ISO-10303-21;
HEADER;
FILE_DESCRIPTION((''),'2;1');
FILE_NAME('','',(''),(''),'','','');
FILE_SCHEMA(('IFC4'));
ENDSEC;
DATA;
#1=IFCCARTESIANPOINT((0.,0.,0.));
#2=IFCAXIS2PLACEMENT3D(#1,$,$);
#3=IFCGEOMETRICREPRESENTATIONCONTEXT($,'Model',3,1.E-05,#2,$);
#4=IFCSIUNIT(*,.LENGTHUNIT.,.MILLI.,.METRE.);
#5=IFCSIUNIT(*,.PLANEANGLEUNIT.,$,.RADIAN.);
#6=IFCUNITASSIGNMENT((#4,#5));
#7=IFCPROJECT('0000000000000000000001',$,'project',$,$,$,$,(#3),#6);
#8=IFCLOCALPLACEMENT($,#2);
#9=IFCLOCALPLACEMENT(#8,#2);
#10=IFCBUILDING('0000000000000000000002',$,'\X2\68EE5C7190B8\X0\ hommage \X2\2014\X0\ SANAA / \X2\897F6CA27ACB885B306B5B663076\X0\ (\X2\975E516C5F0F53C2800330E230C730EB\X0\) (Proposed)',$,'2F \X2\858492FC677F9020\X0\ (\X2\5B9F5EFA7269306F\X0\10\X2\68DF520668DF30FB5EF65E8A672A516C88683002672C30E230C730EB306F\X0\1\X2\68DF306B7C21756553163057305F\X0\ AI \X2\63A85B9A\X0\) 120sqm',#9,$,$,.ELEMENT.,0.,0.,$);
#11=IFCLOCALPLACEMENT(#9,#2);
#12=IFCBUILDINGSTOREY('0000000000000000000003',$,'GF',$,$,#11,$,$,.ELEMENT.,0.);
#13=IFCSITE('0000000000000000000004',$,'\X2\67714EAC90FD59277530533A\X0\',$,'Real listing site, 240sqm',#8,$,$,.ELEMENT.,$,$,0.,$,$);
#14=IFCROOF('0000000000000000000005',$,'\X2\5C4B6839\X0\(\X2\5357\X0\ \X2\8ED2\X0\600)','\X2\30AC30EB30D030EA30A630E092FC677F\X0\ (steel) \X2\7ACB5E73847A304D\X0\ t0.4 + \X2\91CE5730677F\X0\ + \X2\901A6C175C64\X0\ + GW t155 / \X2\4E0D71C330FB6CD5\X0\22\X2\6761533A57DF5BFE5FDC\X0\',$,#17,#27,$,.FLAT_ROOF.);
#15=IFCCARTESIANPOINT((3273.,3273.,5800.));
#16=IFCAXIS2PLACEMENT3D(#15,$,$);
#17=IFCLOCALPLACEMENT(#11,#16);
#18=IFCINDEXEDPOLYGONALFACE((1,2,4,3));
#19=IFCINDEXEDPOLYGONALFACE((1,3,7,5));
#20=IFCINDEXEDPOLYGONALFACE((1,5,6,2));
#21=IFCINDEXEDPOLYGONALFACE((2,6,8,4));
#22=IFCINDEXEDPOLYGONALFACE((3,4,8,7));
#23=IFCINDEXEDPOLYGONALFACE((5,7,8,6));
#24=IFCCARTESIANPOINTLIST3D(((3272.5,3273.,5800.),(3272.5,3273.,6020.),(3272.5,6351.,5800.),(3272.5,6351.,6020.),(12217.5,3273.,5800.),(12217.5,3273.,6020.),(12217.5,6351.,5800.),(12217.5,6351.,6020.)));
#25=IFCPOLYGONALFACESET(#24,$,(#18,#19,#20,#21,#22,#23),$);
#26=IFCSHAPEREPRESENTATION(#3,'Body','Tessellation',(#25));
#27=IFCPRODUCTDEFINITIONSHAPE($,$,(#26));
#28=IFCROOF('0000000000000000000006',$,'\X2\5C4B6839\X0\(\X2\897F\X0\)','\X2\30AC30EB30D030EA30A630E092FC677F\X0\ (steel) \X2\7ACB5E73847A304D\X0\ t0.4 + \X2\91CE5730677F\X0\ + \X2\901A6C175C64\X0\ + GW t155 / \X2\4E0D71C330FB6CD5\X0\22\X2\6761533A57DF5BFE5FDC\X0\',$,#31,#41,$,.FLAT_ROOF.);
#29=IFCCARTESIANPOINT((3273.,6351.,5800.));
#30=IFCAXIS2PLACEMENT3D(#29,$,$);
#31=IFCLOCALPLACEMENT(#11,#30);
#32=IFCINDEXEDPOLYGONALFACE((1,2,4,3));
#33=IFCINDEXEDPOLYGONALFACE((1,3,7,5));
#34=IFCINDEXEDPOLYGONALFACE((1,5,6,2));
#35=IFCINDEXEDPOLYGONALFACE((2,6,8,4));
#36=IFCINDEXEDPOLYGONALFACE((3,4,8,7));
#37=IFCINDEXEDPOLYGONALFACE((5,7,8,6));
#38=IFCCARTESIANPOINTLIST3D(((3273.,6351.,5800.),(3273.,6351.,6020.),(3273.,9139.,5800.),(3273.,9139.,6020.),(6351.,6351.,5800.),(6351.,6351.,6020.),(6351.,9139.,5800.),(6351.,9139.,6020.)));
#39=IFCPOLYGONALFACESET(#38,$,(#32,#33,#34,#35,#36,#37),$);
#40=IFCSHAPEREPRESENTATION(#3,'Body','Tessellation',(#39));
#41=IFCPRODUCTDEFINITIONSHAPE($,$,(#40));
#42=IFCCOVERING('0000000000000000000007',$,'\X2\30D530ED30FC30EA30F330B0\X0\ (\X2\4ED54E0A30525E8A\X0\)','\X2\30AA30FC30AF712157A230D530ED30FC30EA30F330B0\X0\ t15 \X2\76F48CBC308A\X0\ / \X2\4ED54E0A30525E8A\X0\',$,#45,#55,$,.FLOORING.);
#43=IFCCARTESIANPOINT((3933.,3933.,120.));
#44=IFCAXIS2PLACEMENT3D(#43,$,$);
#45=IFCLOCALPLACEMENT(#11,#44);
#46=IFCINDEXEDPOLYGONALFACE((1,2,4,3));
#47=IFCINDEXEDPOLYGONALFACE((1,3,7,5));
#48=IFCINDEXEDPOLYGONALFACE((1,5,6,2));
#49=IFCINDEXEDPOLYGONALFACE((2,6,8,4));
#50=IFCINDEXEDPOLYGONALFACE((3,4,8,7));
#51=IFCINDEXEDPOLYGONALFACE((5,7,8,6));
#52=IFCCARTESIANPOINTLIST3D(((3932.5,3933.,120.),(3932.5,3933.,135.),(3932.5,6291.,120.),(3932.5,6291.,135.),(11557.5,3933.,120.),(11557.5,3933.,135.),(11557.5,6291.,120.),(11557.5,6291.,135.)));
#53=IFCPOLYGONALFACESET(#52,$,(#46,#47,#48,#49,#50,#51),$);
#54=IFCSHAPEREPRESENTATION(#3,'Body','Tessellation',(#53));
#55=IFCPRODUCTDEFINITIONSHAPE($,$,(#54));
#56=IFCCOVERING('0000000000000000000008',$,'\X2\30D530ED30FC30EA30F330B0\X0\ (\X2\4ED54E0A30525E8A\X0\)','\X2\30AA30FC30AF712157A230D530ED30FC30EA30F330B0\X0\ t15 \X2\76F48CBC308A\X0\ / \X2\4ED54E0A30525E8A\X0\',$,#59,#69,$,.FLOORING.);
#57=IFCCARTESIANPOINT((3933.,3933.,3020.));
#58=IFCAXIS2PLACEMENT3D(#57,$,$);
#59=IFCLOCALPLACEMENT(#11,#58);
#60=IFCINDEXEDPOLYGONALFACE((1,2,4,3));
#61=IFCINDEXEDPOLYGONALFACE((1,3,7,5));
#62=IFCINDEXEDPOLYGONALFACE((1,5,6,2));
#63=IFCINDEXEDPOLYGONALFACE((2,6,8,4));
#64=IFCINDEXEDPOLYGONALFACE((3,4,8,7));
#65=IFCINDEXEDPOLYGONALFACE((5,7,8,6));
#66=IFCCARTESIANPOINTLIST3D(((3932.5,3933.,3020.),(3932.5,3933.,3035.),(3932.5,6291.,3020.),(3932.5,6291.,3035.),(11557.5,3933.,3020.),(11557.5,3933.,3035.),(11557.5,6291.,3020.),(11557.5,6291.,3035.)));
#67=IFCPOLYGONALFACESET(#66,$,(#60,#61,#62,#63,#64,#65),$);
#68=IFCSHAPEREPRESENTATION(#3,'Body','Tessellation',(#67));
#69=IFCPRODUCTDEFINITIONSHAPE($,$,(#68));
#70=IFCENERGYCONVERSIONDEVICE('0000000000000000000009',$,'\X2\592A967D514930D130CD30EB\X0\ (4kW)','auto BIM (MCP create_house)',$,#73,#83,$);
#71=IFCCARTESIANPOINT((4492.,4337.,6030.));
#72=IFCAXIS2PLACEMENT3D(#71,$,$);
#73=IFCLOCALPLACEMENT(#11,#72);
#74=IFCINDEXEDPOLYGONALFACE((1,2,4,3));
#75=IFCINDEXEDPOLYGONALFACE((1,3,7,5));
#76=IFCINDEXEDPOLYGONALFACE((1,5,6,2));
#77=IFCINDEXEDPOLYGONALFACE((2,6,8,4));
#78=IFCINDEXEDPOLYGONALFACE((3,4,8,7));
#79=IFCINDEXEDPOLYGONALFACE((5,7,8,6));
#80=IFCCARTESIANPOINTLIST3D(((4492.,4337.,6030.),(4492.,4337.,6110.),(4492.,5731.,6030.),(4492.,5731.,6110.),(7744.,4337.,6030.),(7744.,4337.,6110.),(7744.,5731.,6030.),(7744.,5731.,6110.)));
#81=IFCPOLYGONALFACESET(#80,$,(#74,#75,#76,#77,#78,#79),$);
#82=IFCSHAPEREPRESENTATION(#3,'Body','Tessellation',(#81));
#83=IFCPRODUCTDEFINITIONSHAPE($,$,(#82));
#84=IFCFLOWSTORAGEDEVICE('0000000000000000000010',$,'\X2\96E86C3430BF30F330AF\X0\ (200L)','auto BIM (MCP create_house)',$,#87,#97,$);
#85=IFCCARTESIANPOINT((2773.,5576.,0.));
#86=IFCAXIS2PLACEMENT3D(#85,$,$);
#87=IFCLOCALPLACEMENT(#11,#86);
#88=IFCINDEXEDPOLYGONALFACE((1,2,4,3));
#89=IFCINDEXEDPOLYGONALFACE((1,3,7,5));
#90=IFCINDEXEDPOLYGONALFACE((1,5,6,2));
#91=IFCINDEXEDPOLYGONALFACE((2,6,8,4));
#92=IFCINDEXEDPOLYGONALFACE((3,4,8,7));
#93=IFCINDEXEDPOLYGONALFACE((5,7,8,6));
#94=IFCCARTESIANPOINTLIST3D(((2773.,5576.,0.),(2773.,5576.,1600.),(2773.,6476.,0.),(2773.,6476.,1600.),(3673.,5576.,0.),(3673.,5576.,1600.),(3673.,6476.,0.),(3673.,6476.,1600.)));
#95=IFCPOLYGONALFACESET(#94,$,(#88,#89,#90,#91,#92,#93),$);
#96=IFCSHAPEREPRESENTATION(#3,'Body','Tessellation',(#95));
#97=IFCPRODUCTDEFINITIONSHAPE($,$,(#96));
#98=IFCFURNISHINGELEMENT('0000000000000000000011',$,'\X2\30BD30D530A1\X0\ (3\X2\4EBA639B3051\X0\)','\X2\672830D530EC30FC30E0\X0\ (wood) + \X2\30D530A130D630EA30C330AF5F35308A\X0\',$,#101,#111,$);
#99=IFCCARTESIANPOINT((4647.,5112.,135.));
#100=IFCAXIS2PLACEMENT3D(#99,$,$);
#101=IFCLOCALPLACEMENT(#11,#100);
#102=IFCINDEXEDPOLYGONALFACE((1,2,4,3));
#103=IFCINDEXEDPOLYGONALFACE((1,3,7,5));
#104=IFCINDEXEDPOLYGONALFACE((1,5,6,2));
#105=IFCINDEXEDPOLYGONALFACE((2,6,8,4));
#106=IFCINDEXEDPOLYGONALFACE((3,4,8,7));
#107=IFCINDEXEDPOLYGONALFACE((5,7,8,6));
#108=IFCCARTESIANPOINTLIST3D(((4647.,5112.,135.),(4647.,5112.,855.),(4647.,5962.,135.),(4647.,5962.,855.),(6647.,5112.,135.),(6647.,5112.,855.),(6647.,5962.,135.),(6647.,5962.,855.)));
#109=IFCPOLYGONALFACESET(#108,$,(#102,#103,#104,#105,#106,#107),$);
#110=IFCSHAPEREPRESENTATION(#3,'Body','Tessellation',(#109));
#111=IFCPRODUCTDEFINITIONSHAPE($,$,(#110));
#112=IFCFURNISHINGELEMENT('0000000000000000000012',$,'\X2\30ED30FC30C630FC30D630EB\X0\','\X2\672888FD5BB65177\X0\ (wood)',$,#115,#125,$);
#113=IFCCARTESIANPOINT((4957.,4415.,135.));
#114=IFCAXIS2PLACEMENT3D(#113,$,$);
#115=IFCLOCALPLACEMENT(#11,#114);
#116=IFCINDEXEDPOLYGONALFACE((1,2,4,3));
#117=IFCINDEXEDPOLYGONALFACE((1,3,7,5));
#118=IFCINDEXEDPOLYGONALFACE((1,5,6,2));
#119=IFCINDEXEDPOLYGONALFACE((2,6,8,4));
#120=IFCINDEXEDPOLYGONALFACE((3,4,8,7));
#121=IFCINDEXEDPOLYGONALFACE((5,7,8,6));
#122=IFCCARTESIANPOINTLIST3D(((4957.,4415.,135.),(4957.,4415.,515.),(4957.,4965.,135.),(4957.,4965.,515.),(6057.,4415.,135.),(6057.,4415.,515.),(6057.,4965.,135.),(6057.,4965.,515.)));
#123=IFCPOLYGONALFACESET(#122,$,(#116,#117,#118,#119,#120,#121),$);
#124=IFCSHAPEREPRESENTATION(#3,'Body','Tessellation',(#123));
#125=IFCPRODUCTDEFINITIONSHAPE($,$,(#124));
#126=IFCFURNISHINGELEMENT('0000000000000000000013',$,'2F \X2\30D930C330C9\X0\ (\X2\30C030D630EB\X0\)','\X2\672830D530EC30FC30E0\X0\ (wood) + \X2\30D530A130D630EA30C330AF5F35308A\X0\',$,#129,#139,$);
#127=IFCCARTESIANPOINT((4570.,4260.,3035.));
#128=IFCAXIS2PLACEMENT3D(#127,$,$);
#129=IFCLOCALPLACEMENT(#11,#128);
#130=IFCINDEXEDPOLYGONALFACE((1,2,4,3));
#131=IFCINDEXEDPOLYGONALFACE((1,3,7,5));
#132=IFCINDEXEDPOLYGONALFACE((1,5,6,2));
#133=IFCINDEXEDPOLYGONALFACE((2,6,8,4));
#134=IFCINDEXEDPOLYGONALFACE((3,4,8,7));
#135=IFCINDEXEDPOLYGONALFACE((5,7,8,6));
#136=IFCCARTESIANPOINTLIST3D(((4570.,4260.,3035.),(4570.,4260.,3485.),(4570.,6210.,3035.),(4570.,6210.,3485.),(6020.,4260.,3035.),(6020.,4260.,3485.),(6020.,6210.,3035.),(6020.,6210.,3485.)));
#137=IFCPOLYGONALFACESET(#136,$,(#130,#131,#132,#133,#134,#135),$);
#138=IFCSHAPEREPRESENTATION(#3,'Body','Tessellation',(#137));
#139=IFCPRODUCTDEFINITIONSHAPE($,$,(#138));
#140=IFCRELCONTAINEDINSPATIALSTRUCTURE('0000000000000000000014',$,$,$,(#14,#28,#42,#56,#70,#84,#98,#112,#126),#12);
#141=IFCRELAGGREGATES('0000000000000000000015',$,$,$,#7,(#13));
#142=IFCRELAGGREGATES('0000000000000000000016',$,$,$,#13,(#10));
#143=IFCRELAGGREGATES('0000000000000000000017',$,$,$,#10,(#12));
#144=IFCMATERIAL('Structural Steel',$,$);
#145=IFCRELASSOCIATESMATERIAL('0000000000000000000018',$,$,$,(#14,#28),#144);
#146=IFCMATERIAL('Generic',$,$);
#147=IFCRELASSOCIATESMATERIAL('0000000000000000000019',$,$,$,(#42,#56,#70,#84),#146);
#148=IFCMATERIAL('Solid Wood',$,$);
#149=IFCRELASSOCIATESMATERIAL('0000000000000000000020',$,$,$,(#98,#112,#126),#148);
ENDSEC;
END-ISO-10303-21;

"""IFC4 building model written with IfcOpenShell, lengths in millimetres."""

from ifc_helpers import new_model, si_unit, frame, frame_2d, origin, place, context, project, spatial, rectangle, extrude, material, element, save


model = new_model("IFC4")

# Units and contexts
model_context = context("Model", 3, precision=1e-05, world=origin())
ifc_project = project(units=[si_unit("LENGTHUNIT", "METRE", prefix="MILLI"), si_unit("PLANEANGLEUNIT", "RADIAN")], contexts=[model_context])

# Site, building, storey
site_placement = place(None, origin())
site = spatial("IfcSite", under=ifc_project, at=site_placement, Name="東京都大田区", ObjectType="Real listing site, 240sqm", CompositionType="ELEMENT", RefElevation=0.0)
building_placement = place(site_placement, origin())
building = spatial("IfcBuilding", under=site, at=building_placement, Name="森山邸 hommage — SANAA / 西沢立衛に学ぶ (非公式参考モデル) (Proposed)", ObjectType="2F 薄鋼板造 (実建物は10棟分棟・延床未公表。本モデルは1棟に簡略化した AI 推定) 120sqm", CompositionType="ELEMENT", ElevationOfRefHeight=0.0, ElevationOfTerrain=0.0)
storey_placement = place(building_placement, origin())
storey = spatial("IfcBuildingStorey", under=building, at=storey_placement, Name="GF", CompositionType="ELEMENT", Elevation=0.0)

# Shared definitions
ifc_material_1 = material(Name="Solid Wood")

# Roofs
ifc_material_2 = material(Name="Structural Steel")
roof_1_placement = place(storey_placement, frame((3273.0, 3273.0, 5800.0)))
element("IfcRoof", 1, at=roof_1_placement, inside=storey, material=ifc_material_2, Name="屋根(南 軒600)", Description="ガルバリウム鋼板 (steel) 立平葺き t0.4 + 野地板 + 通気層 + GW t155 / 不燃・法22条区域対応", PredefinedType="FLAT_ROOF", context=model_context, shape_type="SweptSolid", body=[
    extrude(rectangle(XDim=8945.0, YDim=3078.0, at=frame_2d((4472.0, 1539.0))), frame((3273.0, 3273.0, 5800.0)), (0.0, 0.0, 1.0), 220.0),
])
roof_2_placement = place(storey_placement, frame((3273.0, 6351.0, 5800.0)))
element("IfcRoof", 2, at=roof_2_placement, inside=storey, material=ifc_material_2, Name="屋根(西)", Description="ガルバリウム鋼板 (steel) 立平葺き t0.4 + 野地板 + 通気層 + GW t155 / 不燃・法22条区域対応", PredefinedType="FLAT_ROOF", context=model_context, shape_type="SweptSolid", body=[
    extrude(rectangle(XDim=3078.0, YDim=2788.0, at=frame_2d((1539.0, 1394.0))), frame((3273.0, 6351.0, 5800.0)), (0.0, 0.0, 1.0), 220.0),
])

# Coverings
ifc_material_3 = material(Name="Generic")
covering_1_placement = place(storey_placement, frame((3933.0, 3933.0, 120.0)))
element("IfcCovering", 3, at=covering_1_placement, inside=storey, material=ifc_material_3, Name="フローリング (仕上げ床)", Description="オーク無垢フローリング t15 直貼り / 仕上げ床", PredefinedType="FLOORING", context=model_context, shape_type="SweptSolid", body=[
    extrude(rectangle(XDim=7625.0, YDim=2358.0, at=frame_2d((3812.0, 1179.0))), frame((3933.0, 3933.0, 120.0)), (0.0, 0.0, 1.0), 15.0),
])
covering_2_placement = place(storey_placement, frame((3933.0, 3933.0, 3020.0)))
element("IfcCovering", 4, at=covering_2_placement, inside=storey, material=ifc_material_3, Name="フローリング (仕上げ床)", Description="オーク無垢フローリング t15 直貼り / 仕上げ床", PredefinedType="FLOORING", context=model_context, shape_type="SweptSolid", body=[
    extrude(rectangle(XDim=7625.0, YDim=2358.0, at=frame_2d((3812.0, 1179.0))), frame((3933.0, 3933.0, 3020.0)), (0.0, 0.0, 1.0), 15.0),
])

# Energy conversion device
energy_conversion_device_placement = place(storey_placement, frame((4492.0, 4337.0, 6030.0)))
element("IfcEnergyConversionDevice", 5, at=energy_conversion_device_placement, inside=storey, material=ifc_material_3, Name="太陽光パネル (4kW)", Description="auto BIM (MCP create_house)", context=model_context, shape_type="SweptSolid", body=[
    extrude(rectangle(XDim=3252.0, YDim=1394.0, at=frame_2d((1626.0, 697.0))), frame((4492.0, 4337.0, 6030.0)), (0.0, 0.0, 1.0), 80.0),
])

# Flow storage device
flow_storage_device_placement = place(storey_placement, frame((2773.0, 5576.0, 0.0)))
element("IfcFlowStorageDevice", 6, at=flow_storage_device_placement, inside=storey, material=ifc_material_3, Name="雨水タンク (200L)", Description="auto BIM (MCP create_house)", context=model_context, shape_type="SweptSolid", body=[
    extrude(rectangle(XDim=900.0, YDim=900.0, at=frame_2d((450.0, 450.0))), frame((2773.0, 5576.0, 0.0)), (0.0, 0.0, 1.0), 1600.0),
])

# Furnishing elements
furnishing_1_placement = place(storey_placement, frame((4647.0, 5112.0, 135.0)))
element("IfcFurnishingElement", 7, at=furnishing_1_placement, inside=storey, material=ifc_material_1, Name="ソファ (3人掛け)", Description="木フレーム (wood) + ファブリック張り", context=model_context, shape_type="SweptSolid", body=[
    extrude(rectangle(XDim=2000.0, YDim=850.0, at=frame_2d((1000.0, 425.0))), frame((4647.0, 5112.0, 135.0)), (0.0, 0.0, 1.0), 720.0),
])
furnishing_2_placement = place(storey_placement, frame((4957.0, 4415.0, 135.0)))
element("IfcFurnishingElement", 8, at=furnishing_2_placement, inside=storey, material=ifc_material_1, Name="ローテーブル", Description="木製家具 (wood)", context=model_context, shape_type="SweptSolid", body=[
    extrude(rectangle(XDim=1100.0, YDim=550.0, at=frame_2d((550.0, 275.0))), frame((4957.0, 4415.0, 135.0)), (0.0, 0.0, 1.0), 380.0),
])
furnishing_3_placement = place(storey_placement, frame((4570.0, 4260.0, 3035.0)))
element("IfcFurnishingElement", 9, at=furnishing_3_placement, inside=storey, material=ifc_material_1, Name="2F ベッド (ダブル)", Description="木フレーム (wood) + ファブリック張り", context=model_context, shape_type="SweptSolid", body=[
    extrude(rectangle(XDim=1450.0, YDim=1950.0, at=frame_2d((725.0, 975.0))), frame((4570.0, 4260.0, 3035.0)), (0.0, 0.0, 1.0), 450.0),
])

save(model, "model.ifc")
